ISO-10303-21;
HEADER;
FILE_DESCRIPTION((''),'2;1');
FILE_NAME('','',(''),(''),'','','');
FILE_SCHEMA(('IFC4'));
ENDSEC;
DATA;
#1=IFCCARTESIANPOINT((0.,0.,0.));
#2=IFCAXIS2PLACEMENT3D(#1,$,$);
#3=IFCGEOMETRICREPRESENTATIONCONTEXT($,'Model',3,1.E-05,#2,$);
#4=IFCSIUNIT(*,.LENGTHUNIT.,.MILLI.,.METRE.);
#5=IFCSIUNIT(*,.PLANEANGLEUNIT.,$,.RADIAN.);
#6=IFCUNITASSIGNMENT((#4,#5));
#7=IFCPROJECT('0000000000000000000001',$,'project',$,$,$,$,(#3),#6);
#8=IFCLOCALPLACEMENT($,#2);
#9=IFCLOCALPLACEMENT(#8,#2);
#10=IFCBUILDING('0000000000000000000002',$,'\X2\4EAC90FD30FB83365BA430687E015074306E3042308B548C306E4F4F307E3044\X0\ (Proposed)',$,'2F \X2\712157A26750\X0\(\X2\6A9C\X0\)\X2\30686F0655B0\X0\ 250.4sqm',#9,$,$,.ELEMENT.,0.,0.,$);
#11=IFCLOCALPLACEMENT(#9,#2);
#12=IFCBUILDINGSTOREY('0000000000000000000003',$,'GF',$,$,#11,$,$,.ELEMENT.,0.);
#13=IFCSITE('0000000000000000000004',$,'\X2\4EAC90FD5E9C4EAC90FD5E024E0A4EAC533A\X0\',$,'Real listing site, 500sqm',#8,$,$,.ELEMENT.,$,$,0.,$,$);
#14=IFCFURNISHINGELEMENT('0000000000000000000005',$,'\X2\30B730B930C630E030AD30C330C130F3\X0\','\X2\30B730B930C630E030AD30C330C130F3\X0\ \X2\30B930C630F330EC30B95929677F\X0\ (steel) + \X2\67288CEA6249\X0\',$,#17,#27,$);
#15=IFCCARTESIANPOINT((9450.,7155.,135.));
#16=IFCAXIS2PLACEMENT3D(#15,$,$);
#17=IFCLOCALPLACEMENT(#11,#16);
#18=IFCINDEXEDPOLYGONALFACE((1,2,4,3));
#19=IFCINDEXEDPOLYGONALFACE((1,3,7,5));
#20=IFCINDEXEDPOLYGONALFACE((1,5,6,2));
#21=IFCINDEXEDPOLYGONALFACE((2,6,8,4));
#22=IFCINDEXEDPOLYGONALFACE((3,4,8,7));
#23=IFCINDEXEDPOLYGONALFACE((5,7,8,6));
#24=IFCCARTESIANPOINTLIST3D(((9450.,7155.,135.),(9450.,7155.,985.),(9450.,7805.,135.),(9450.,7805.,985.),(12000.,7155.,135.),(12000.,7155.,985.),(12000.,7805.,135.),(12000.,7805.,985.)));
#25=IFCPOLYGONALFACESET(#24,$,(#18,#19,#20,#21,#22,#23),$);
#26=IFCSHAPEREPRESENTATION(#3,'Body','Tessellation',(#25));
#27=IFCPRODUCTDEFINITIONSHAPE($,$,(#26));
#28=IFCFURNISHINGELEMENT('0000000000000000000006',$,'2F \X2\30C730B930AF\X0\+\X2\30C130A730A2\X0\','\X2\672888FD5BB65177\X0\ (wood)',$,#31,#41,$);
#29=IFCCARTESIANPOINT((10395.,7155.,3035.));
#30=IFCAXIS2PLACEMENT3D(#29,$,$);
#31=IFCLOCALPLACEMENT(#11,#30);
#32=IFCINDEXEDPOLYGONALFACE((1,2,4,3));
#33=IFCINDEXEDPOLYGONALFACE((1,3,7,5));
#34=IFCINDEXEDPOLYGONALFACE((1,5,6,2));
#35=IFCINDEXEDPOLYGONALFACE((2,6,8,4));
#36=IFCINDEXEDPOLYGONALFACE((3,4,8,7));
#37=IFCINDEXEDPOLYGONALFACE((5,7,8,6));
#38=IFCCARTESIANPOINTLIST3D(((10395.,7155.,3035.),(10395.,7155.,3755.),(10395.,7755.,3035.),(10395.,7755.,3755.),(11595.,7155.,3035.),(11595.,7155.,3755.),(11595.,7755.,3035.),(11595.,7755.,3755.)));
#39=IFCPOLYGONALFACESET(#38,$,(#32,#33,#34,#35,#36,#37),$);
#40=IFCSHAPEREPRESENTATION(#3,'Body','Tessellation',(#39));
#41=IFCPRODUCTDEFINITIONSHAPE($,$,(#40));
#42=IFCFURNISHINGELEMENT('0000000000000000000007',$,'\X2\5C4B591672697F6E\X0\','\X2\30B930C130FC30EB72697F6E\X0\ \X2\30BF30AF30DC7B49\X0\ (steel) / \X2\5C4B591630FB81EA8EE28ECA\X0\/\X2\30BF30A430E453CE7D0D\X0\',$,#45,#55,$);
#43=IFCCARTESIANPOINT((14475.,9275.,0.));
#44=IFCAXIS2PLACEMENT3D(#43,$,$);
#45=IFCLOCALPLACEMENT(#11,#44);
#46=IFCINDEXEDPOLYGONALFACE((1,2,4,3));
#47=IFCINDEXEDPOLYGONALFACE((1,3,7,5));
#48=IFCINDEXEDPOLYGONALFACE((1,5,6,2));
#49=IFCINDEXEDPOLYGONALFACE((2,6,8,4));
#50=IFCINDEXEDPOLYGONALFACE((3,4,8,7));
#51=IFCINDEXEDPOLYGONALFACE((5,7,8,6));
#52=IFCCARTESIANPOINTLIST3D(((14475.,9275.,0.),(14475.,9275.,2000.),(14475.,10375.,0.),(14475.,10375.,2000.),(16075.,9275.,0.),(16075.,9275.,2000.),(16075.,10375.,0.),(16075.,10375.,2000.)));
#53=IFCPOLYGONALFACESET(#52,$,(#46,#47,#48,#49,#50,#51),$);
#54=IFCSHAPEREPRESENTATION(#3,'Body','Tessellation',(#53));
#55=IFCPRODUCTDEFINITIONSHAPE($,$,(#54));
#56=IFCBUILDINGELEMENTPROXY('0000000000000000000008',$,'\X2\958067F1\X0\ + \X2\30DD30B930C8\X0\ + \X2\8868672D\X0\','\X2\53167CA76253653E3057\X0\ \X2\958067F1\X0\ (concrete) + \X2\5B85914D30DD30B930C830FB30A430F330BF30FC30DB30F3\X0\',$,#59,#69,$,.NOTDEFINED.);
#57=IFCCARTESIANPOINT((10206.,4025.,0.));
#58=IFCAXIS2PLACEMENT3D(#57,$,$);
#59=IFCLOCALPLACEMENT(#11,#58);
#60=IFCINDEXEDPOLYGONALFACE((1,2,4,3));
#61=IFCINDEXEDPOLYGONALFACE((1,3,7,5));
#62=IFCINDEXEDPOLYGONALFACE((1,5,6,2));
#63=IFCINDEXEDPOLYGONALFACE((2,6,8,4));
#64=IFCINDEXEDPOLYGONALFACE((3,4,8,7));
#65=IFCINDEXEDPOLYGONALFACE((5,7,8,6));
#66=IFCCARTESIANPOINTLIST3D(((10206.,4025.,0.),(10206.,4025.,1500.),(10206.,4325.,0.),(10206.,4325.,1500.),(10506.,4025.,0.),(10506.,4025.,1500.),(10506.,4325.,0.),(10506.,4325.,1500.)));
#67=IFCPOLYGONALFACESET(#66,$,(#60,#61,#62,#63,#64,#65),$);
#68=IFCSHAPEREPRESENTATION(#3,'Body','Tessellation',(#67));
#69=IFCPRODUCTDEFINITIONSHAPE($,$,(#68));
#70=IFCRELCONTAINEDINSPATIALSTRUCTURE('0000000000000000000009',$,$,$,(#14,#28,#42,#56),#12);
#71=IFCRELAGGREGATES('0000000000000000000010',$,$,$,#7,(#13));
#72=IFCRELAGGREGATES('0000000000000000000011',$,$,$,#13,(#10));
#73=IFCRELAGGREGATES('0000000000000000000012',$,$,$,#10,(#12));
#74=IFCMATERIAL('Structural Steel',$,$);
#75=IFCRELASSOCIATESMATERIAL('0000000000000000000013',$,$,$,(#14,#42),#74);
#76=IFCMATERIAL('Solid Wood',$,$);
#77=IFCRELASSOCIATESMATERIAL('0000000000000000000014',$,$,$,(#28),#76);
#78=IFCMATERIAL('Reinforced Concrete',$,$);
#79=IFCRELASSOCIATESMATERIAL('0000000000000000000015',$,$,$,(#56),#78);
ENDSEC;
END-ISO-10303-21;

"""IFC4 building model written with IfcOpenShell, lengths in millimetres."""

from ifc_helpers import new_model, si_unit, frame, frame_2d, origin, place, context, project, spatial, rectangle, extrude, material, element, save


model = new_model("IFC4")

# Units and contexts
model_context = context("Model", 3, precision=1e-05, world=origin())
ifc_project = project(units=[si_unit("LENGTHUNIT", "METRE", prefix="MILLI"), si_unit("PLANEANGLEUNIT", "RADIAN")], contexts=[model_context])

# Site, building, storey
site_placement = place(None, origin())
site = spatial("IfcSite", under=ifc_project, at=site_placement, Name="京都府京都市上京区", ObjectType="Real listing site, 500sqm", CompositionType="ELEMENT", RefElevation=0.0)
building_placement = place(site_placement, origin())
building = spatial("IfcBuilding", under=site, at=building_placement, Name="京都・茶室と縁側のある和の住まい (Proposed)", ObjectType="2F 無垢材(檜)と漆喰 250.4sqm", CompositionType="ELEMENT", ElevationOfRefHeight=0.0, ElevationOfTerrain=0.0)
storey_placement = place(building_placement, origin())
storey = spatial("IfcBuildingStorey", under=building, at=storey_placement, Name="GF", CompositionType="ELEMENT", Elevation=0.0)

# Shared definitions
ifc_material_1 = material(Name="Solid Wood")

# Shared definitions
ifc_material_2 = material(Name="Reinforced Concrete")

# Shared definitions
ifc_material_3 = material(Name="Structural Steel")

# Furnishing elements
furnishing_1_placement = place(storey_placement, frame((9450.0, 7155.0, 135.0)))
element("IfcFurnishingElement", 1, at=furnishing_1_placement, inside=storey, material=ifc_material_3, Name="システムキッチン", Description="システムキッチン ステンレス天板 (steel) + 木質扉", context=model_context, shape_type="SweptSolid", body=[
    extrude(rectangle(XDim=2550.0, YDim=650.0, at=frame_2d((1275.0, 325.0))), frame((9450.0, 7155.0, 135.0)), (0.0, 0.0, 1.0), 850.0),
])
furnishing_2_placement = place(storey_placement, frame((10395.0, 7155.0, 3035.0)))
element("IfcFurnishingElement", 2, at=furnishing_2_placement, inside=storey, material=ifc_material_1, Name="2F デスク+チェア", Description="木製家具 (wood)", context=model_context, shape_type="SweptSolid", body=[
    extrude(rectangle(XDim=1200.0, YDim=600.0, at=frame_2d((600.0, 300.0))), frame((10395.0, 7155.0, 3035.0)), (0.0, 0.0, 1.0), 720.0),
])
furnishing_3_placement = place(storey_placement, frame((14475.0, 9275.0, 0.0)))
element("IfcFurnishingElement", 3, at=furnishing_3_placement, inside=storey, material=ifc_material_3, Name="屋外物置", Description="スチール物置 タクボ等 (steel) / 屋外・自転車/タイヤ収納", context=model_context, shape_type="SweptSolid", body=[
    extrude(rectangle(XDim=1600.0, YDim=1100.0, at=frame_2d((800.0, 550.0))), frame((14475.0, 9275.0, 0.0)), (0.0, 0.0, 1.0), 2000.0),
])

# Building element proxy
proxy_placement = place(storey_placement, frame((10206.0, 4025.0, 0.0)))
element("IfcBuildingElementProxy", 4, at=proxy_placement, inside=storey, material=ifc_material_2, Name="門柱 + ポスト + 表札", Description="化粧打放し 門柱 (concrete) + 宅配ポスト・インターホン", PredefinedType="NOTDEFINED", context=model_context, shape_type="SweptSolid", body=[
    extrude(rectangle(XDim=300.0, YDim=300.0, at=frame_2d((150.0, 150.0))), frame((10206.0, 4025.0, 0.0)), (0.0, 0.0, 1.0), 1500.0),
])

save(model, "model.ifc")
